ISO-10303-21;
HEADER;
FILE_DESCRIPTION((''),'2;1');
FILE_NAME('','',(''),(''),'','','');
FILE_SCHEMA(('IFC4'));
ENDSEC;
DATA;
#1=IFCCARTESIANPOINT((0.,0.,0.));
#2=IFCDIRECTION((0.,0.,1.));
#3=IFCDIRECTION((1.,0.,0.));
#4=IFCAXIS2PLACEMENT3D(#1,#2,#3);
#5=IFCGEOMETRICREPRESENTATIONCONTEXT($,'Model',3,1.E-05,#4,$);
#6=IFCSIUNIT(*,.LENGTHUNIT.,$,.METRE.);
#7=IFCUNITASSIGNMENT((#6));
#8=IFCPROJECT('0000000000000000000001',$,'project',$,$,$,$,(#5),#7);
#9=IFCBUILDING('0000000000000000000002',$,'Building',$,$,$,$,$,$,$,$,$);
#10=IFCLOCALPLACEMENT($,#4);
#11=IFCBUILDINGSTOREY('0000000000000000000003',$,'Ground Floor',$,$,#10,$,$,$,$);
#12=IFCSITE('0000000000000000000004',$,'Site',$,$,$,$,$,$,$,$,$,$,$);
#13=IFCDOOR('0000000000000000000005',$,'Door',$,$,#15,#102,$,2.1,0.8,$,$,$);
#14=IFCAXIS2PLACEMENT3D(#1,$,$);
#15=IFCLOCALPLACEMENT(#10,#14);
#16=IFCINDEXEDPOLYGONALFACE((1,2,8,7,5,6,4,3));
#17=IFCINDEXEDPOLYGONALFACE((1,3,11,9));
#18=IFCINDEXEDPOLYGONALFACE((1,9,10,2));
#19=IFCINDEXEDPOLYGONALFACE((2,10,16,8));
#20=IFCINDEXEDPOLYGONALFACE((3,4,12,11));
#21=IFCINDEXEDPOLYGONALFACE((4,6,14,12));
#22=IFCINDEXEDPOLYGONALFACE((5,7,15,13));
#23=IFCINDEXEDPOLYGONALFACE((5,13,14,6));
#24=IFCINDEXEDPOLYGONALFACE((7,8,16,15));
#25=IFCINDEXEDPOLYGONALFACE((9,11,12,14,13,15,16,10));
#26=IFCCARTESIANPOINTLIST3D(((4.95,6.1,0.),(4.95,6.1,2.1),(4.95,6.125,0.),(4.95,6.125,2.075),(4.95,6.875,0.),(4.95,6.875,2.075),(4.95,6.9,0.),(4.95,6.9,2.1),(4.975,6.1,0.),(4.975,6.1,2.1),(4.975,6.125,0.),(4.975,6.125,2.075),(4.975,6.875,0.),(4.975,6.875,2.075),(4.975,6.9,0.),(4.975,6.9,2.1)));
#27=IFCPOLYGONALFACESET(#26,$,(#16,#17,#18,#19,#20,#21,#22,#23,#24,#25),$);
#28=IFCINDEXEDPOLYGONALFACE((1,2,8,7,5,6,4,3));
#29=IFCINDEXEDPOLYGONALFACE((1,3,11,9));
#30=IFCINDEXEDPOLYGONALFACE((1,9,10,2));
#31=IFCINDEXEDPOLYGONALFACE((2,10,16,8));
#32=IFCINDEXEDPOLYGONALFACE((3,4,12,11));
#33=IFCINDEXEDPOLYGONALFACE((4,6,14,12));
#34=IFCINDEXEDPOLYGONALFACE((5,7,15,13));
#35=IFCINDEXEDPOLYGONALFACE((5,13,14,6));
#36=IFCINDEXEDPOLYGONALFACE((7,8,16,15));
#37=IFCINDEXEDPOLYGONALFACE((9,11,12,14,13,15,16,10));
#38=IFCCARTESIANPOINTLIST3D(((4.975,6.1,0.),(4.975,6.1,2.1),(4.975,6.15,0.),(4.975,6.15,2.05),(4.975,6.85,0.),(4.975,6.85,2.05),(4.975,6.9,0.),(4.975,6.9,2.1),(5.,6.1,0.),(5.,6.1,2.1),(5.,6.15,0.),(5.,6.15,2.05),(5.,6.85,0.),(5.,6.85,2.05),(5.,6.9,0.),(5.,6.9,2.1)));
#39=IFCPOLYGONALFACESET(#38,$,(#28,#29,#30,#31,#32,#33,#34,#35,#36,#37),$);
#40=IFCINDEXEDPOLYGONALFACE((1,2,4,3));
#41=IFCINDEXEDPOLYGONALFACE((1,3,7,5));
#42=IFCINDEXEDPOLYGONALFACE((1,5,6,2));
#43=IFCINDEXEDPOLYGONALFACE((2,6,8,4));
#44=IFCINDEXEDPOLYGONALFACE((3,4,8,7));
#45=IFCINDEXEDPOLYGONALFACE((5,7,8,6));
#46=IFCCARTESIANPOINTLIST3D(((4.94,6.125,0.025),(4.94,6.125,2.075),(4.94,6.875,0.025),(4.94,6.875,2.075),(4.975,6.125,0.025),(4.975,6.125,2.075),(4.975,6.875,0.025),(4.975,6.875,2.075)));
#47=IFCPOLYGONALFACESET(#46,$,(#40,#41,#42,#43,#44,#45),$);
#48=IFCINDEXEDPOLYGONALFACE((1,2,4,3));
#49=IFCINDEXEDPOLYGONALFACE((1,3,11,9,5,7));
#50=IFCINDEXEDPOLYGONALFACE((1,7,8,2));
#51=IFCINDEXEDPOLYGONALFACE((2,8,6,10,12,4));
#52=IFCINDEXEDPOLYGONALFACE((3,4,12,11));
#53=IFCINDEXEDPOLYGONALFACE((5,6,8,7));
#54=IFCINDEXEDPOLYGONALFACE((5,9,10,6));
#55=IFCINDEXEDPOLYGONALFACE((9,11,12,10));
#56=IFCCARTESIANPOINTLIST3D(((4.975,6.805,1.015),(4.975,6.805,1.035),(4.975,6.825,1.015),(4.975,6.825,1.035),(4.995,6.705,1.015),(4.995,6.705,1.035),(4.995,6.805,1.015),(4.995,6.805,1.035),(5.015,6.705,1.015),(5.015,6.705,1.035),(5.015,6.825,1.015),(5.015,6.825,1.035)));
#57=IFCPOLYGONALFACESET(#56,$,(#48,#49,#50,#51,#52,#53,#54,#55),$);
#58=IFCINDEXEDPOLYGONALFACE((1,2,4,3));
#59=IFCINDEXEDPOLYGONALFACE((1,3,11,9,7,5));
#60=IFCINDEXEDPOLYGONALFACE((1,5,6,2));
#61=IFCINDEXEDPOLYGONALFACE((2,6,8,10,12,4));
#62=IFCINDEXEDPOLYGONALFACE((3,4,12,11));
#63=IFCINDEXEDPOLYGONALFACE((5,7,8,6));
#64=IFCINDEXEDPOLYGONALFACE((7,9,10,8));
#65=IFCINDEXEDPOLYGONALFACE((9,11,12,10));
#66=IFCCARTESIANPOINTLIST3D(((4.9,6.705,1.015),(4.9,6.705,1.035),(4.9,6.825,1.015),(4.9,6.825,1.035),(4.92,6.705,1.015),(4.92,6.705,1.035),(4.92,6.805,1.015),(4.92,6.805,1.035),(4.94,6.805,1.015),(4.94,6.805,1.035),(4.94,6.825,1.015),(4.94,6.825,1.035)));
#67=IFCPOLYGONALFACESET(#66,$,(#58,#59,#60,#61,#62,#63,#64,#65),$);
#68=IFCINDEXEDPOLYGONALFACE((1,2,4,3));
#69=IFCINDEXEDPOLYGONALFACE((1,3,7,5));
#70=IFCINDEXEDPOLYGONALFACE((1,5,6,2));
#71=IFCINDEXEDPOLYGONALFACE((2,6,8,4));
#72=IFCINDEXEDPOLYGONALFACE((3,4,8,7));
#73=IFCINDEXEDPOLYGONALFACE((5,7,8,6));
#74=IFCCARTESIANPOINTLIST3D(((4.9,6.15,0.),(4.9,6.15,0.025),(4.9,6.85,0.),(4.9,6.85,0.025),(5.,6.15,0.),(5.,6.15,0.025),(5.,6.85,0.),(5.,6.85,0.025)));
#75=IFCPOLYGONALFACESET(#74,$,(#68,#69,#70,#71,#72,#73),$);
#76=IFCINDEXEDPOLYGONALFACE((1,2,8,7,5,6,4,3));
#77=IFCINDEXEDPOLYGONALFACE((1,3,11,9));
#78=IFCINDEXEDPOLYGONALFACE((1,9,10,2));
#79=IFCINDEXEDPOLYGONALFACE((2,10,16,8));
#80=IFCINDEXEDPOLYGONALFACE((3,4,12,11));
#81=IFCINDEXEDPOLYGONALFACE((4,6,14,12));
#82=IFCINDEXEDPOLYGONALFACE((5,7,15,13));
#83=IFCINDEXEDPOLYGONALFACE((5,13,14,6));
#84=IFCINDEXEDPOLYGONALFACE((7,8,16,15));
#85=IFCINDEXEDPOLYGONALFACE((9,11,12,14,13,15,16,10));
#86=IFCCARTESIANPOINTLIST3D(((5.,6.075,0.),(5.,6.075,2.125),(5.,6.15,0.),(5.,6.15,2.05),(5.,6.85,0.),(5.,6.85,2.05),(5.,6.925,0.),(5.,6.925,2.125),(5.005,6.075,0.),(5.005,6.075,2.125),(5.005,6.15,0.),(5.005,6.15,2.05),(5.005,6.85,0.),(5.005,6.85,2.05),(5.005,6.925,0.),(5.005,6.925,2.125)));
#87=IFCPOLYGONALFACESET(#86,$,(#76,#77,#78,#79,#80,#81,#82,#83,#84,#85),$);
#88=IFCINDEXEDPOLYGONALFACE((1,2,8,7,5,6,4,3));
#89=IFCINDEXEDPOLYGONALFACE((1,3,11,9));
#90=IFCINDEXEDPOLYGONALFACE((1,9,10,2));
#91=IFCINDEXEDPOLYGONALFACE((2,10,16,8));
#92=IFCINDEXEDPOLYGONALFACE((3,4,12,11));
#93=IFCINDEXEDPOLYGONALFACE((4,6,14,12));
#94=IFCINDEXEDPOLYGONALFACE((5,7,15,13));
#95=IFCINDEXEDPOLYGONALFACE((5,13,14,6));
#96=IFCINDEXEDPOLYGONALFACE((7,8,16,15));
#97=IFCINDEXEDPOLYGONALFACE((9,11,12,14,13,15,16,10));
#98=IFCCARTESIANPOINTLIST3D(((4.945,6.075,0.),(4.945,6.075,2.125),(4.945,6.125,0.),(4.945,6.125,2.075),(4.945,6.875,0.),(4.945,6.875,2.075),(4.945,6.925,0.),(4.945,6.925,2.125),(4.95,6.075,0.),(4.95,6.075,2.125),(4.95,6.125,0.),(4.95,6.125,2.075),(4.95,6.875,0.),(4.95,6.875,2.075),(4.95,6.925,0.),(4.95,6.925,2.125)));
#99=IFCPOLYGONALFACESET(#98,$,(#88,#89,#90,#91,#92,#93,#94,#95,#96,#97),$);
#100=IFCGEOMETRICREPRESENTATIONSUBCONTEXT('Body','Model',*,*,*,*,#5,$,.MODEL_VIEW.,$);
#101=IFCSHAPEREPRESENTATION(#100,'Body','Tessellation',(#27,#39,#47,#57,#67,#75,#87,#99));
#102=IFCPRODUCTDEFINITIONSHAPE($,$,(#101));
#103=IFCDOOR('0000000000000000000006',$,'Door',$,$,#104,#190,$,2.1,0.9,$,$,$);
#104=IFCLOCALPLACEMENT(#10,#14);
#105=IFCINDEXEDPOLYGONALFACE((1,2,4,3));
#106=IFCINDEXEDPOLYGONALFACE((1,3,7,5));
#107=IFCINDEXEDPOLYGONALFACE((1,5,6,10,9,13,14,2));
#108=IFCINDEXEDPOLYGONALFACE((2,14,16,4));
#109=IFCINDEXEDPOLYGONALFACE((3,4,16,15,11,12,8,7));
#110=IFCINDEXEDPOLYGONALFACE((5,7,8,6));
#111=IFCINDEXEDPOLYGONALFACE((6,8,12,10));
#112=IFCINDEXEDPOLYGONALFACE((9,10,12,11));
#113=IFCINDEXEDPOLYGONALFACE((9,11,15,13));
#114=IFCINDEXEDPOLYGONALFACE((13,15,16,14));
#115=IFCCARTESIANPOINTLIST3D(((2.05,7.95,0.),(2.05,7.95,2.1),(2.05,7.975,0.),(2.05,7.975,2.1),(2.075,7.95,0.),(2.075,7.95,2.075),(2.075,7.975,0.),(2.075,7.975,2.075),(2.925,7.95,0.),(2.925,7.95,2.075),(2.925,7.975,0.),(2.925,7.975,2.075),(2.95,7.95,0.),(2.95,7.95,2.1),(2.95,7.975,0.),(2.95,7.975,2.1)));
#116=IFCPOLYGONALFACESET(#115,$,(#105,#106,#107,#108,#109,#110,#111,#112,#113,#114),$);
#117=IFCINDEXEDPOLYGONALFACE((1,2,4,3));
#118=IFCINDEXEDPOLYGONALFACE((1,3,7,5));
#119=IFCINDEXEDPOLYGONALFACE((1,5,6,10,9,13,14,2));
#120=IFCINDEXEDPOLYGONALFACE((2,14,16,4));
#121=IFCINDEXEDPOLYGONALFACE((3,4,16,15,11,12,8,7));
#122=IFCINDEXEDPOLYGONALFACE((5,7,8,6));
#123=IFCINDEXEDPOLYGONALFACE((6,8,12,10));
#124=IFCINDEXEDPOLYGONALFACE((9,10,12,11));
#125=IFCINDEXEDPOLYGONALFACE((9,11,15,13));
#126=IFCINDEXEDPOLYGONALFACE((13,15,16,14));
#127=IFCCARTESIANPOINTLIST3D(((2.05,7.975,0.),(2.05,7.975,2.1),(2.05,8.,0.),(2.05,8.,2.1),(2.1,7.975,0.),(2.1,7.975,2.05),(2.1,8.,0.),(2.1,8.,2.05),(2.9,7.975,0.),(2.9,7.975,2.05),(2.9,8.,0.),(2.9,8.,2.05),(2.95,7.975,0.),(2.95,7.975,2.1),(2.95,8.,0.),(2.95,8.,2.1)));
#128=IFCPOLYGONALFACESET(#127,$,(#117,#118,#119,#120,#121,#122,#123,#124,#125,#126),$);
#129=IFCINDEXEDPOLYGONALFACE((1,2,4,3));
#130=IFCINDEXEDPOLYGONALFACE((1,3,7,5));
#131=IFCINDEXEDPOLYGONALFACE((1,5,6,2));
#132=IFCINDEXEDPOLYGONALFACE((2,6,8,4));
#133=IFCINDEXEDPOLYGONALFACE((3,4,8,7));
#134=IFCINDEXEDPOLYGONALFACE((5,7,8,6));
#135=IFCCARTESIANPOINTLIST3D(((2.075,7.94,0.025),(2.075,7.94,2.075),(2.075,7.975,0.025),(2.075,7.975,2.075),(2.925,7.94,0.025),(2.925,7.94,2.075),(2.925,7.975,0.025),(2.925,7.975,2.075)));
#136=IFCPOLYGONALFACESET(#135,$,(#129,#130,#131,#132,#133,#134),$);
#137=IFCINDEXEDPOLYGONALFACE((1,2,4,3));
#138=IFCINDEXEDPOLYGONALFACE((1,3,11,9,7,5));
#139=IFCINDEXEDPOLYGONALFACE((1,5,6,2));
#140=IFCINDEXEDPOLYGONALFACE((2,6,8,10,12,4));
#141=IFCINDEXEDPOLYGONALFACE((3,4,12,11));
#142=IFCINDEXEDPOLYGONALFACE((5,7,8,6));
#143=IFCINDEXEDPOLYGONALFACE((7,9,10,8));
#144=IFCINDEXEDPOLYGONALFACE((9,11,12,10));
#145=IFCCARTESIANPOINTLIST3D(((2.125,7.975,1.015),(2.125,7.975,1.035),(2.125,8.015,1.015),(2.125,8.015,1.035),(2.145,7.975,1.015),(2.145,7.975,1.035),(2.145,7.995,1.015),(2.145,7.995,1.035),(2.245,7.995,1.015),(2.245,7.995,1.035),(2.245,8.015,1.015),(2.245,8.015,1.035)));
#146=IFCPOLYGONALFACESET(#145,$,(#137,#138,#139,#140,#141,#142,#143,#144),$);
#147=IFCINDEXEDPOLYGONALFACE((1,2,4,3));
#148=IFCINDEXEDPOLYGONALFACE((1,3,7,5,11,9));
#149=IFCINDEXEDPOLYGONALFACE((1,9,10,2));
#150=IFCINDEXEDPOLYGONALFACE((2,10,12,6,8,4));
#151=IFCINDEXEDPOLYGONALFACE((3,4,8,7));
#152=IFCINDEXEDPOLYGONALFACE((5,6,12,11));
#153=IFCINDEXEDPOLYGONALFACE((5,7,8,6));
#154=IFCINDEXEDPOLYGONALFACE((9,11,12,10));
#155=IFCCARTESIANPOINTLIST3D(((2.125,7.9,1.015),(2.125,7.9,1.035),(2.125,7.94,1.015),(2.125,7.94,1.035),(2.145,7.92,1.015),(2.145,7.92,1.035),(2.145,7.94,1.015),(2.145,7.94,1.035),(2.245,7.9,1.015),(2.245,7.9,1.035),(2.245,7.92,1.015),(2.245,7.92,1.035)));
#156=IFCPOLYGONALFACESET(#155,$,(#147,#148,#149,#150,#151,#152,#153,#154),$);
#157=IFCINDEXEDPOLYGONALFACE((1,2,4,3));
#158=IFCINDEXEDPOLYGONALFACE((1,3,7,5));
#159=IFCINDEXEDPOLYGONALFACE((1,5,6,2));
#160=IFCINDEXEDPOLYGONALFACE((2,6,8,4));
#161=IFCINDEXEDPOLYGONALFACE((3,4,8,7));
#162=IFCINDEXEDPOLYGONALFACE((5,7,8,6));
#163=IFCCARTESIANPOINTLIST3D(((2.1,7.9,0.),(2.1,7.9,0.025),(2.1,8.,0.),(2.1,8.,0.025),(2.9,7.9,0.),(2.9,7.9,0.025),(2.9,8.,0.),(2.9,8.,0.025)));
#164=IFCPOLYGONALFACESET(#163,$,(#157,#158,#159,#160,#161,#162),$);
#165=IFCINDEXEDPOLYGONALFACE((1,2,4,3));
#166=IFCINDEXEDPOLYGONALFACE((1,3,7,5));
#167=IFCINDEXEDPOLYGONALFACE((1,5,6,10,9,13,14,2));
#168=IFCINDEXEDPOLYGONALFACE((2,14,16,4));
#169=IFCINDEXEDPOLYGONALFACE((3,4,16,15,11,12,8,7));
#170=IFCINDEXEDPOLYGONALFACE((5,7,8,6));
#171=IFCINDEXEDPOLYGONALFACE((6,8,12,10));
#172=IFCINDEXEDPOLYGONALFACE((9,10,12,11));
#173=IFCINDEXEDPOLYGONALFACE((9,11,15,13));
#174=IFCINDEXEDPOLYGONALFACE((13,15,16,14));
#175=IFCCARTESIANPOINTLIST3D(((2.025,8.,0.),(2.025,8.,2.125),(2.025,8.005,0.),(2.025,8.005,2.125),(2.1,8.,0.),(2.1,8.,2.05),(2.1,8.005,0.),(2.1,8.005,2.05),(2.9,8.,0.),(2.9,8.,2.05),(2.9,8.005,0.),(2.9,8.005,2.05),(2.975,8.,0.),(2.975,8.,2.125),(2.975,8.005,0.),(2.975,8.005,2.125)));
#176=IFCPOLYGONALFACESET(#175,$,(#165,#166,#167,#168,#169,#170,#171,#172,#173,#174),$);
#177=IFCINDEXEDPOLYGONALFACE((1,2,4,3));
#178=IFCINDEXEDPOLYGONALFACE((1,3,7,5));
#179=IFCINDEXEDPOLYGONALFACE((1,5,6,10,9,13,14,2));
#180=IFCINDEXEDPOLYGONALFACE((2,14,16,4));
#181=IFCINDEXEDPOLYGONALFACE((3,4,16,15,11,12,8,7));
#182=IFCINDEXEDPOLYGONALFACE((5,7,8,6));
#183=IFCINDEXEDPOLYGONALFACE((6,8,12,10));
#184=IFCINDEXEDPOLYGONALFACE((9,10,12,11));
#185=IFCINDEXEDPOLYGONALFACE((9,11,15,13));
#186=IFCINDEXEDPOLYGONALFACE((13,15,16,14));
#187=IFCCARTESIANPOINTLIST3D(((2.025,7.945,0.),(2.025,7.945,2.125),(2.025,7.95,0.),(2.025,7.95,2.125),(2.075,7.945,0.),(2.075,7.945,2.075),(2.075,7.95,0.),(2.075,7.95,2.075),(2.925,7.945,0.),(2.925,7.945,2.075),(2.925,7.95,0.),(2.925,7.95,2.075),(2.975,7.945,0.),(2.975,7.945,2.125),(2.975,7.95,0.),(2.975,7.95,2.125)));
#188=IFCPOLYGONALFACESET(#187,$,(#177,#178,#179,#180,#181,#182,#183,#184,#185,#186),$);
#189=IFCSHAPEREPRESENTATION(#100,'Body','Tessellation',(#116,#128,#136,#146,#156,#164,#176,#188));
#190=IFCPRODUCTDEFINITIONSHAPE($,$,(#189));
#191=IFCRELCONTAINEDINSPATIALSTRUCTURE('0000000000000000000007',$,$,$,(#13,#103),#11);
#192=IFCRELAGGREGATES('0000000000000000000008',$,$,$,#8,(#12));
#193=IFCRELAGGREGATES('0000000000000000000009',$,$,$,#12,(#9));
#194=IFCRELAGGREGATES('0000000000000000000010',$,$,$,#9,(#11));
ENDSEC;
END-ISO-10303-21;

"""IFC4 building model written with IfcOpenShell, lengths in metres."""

from ifc_helpers import new_model, si_unit, frame, origin_with_axes, place, context, subcontext, project, spatial, line, indexed_curve, outline, extrude, element, save


model = new_model("IFC4")

# Units and contexts
model_context = context("Model", 3, precision=1e-05, world=origin_with_axes())
body_context = subcontext(model_context, "Body", "Model", "MODEL_VIEW")
ifc_project = project(units=[si_unit("LENGTHUNIT", "METRE")], contexts=[model_context])

# Site, building, storey
site = spatial("IfcSite", under=ifc_project, Name="Site")
building = spatial("IfcBuilding", under=site, Name="Building")
storey_placement = place(None, origin_with_axes())
storey = spatial("IfcBuildingStorey", under=building, at=storey_placement, Name="Ground Floor")

# Doors
door_1_placement = place(storey_placement, frame((5.0, 6.1, 0.0), z_axis=(0.0, 0.0, 1.0), x_axis=(0.0, 1.0, 0.0)))
element("IfcDoor", 1, at=door_1_placement, inside=storey, Name="Door", OverallHeight=2.1, OverallWidth=0.8, context=body_context, shape_type="SweptSolid", body=[
    extrude(outline(indexed_curve([(0.0, 0.0), (0.0, 2.1), (0.8, 2.1), (0.8, 0.0), (0.775, 0.0), (0.775, 2.075), (0.025, 2.075), (0.025, 0.0)], segments=[line(1, 2, 3, 4, 5, 6, 7, 8, 1)])), frame((0.0, 0.025, 0.0), z_axis=(0.0, -1.0, 0.0), x_axis=(1.0, 0.0, 0.0)), (0.0, 0.0, -1.0), 0.025),
    extrude(outline(indexed_curve([(0.0, 0.0), (0.0, 2.1), (0.8, 2.1), (0.8, 0.0), (0.75, 0.0), (0.75, 2.05), (0.05, 2.05), (0.05, 0.0)], segments=[line(1, 2, 3, 4, 5, 6, 7, 8, 1)])), frame((0.0, 0.0, 0.0), z_axis=(0.0, -1.0, 0.0), x_axis=(1.0, 0.0, 0.0)), (0.0, 0.0, -1.0), 0.025),
    extrude(outline(indexed_curve([(0.0, 0.0), (0.75, 0.0), (0.75, 0.035), (0.0, 0.035)], segments=[line(1, 2, 3, 4, 1)])), frame((0.025, 0.025, 0.025), z_axis=(0.0, 0.0, 1.0), x_axis=(1.0, 0.0, 0.0)), (0.0, 0.0, 1.0), 2.05),
    extrude(outline(indexed_curve([(0.0, 0.0), (0.0, -0.04), (-0.12, -0.04), (-0.12, -0.02), (-0.02, -0.02), (-0.02, 0.0)], segments=[line(1, 2, 3, 4, 5, 6, 1)])), frame((0.725, 0.025, 1.015), z_axis=(0.0, 0.0, 1.0), x_axis=(1.0, 0.0, 0.0)), (0.0, 0.0, 1.0), 0.02),
    extrude(outline(indexed_curve([(0.0, 0.0), (0.0, 0.04), (-0.12, 0.04), (-0.12, 0.02), (-0.02, 0.02), (-0.02, 0.0)], segments=[line(1, 2, 3, 4, 5, 6, 1)])), frame((0.725, 0.06, 1.015), z_axis=(0.0, 0.0, 1.0), x_axis=(1.0, 0.0, 0.0)), (0.0, 0.0, 1.0), 0.02),
    extrude(outline(indexed_curve([(0.0, 0.0), (0.7, 0.0), (0.7, 0.1), (0.0, 0.1)], segments=[line(1, 2, 3, 4, 1)])), frame((0.05, 0.0, 0.0), z_axis=(0.0, 0.0, 1.0), x_axis=(1.0, 0.0, 0.0)), (0.0, 0.0, 1.0), 0.025),
    extrude(outline(indexed_curve([(0.0, 0.0), (0.0, 2.125), (0.85, 2.125), (0.85, 0.0), (0.775, 0.0), (0.775, 2.05), (0.075, 2.05), (0.075, 0.0)], segments=[line(1, 2, 3, 4, 5, 6, 7, 8, 1)])), frame((-0.025, -0.005, 0.0), z_axis=(0.0, -1.0, 0.0), x_axis=(1.0, 0.0, 0.0)), (0.0, 0.0, -1.0), 0.005),
    extrude(outline(indexed_curve([(0.0, 0.0), (0.0, 2.125), (0.85, 2.125), (0.85, 0.0), (0.8, 0.0), (0.8, 2.075), (0.05, 2.075), (0.05, 0.0)], segments=[line(1, 2, 3, 4, 5, 6, 7, 8, 1)])), frame((-0.025, 0.05, 0.0), z_axis=(0.0, -1.0, 0.0), x_axis=(1.0, 0.0, 0.0)), (0.0, 0.0, -1.0), 0.005),
])
door_2_placement = place(storey_placement, frame((2.95, 8.0, 0.0), z_axis=(0.0, 0.0, 1.0), x_axis=(-1.0, 0.0, 0.0)))
element("IfcDoor", 2, at=door_2_placement, inside=storey, Name="Door", OverallHeight=2.1, OverallWidth=0.9, context=body_context, shape_type="SweptSolid", body=[
    extrude(outline(indexed_curve([(0.0, 0.0), (0.0, 2.1), (0.9, 2.1), (0.9, 0.0), (0.875, 0.0), (0.875, 2.075), (0.025, 2.075), (0.025, 0.0)], segments=[line(1, 2, 3, 4, 5, 6, 7, 8, 1)])), frame((0.0, 0.025, 0.0), z_axis=(0.0, -1.0, 0.0), x_axis=(1.0, 0.0, 0.0)), (0.0, 0.0, -1.0), 0.025),
    extrude(outline(indexed_curve([(0.0, 0.0), (0.0, 2.1), (0.9, 2.1), (0.9, 0.0), (0.85, 0.0), (0.85, 2.05), (0.05, 2.05), (0.05, 0.0)], segments=[line(1, 2, 3, 4, 5, 6, 7, 8, 1)])), frame((0.0, 0.0, 0.0), z_axis=(0.0, -1.0, 0.0), x_axis=(1.0, 0.0, 0.0)), (0.0, 0.0, -1.0), 0.025),
    extrude(outline(indexed_curve([(0.0, 0.0), (0.85, 0.0), (0.85, 0.035), (0.0, 0.035)], segments=[line(1, 2, 3, 4, 1)])), frame((0.025, 0.025, 0.025), z_axis=(0.0, 0.0, 1.0), x_axis=(1.0, 0.0, 0.0)), (0.0, 0.0, 1.0), 2.05),
    extrude(outline(indexed_curve([(0.0, 0.0), (0.0, -0.04), (-0.12, -0.04), (-0.12, -0.02), (-0.02, -0.02), (-0.02, 0.0)], segments=[line(1, 2, 3, 4, 5, 6, 1)])), frame((0.825, 0.025, 1.015), z_axis=(0.0, 0.0, 1.0), x_axis=(1.0, 0.0, 0.0)), (0.0, 0.0, 1.0), 0.02),
    extrude(outline(indexed_curve([(0.0, 0.0), (0.0, 0.04), (-0.12, 0.04), (-0.12, 0.02), (-0.02, 0.02), (-0.02, 0.0)], segments=[line(1, 2, 3, 4, 5, 6, 1)])), frame((0.825, 0.06, 1.015), z_axis=(0.0, 0.0, 1.0), x_axis=(1.0, 0.0, 0.0)), (0.0, 0.0, 1.0), 0.02),
    extrude(outline(indexed_curve([(0.0, 0.0), (0.8, 0.0), (0.8, 0.1), (0.0, 0.1)], segments=[line(1, 2, 3, 4, 1)])), frame((0.05, 0.0, 0.0), z_axis=(0.0, 0.0, 1.0), x_axis=(1.0, 0.0, 0.0)), (0.0, 0.0, 1.0), 0.025),
    extrude(outline(indexed_curve([(0.0, 0.0), (0.0, 2.125), (0.95, 2.125), (0.95, 0.0), (0.875, 0.0), (0.875, 2.05), (0.075, 2.05), (0.075, 0.0)], segments=[line(1, 2, 3, 4, 5, 6, 7, 8, 1)])), frame((-0.025, -0.005, 0.0), z_axis=(0.0, -1.0, 0.0), x_axis=(1.0, 0.0, 0.0)), (0.0, 0.0, -1.0), 0.005),
    extrude(outline(indexed_curve([(0.0, 0.0), (0.0, 2.125), (0.95, 2.125), (0.95, 0.0), (0.9, 0.0), (0.9, 2.075), (0.05, 2.075), (0.05, 0.0)], segments=[line(1, 2, 3, 4, 5, 6, 7, 8, 1)])), frame((-0.025, 0.05, 0.0), z_axis=(0.0, -1.0, 0.0), x_axis=(1.0, 0.0, 0.0)), (0.0, 0.0, -1.0), 0.005),
])

save(model, "model.ifc")
